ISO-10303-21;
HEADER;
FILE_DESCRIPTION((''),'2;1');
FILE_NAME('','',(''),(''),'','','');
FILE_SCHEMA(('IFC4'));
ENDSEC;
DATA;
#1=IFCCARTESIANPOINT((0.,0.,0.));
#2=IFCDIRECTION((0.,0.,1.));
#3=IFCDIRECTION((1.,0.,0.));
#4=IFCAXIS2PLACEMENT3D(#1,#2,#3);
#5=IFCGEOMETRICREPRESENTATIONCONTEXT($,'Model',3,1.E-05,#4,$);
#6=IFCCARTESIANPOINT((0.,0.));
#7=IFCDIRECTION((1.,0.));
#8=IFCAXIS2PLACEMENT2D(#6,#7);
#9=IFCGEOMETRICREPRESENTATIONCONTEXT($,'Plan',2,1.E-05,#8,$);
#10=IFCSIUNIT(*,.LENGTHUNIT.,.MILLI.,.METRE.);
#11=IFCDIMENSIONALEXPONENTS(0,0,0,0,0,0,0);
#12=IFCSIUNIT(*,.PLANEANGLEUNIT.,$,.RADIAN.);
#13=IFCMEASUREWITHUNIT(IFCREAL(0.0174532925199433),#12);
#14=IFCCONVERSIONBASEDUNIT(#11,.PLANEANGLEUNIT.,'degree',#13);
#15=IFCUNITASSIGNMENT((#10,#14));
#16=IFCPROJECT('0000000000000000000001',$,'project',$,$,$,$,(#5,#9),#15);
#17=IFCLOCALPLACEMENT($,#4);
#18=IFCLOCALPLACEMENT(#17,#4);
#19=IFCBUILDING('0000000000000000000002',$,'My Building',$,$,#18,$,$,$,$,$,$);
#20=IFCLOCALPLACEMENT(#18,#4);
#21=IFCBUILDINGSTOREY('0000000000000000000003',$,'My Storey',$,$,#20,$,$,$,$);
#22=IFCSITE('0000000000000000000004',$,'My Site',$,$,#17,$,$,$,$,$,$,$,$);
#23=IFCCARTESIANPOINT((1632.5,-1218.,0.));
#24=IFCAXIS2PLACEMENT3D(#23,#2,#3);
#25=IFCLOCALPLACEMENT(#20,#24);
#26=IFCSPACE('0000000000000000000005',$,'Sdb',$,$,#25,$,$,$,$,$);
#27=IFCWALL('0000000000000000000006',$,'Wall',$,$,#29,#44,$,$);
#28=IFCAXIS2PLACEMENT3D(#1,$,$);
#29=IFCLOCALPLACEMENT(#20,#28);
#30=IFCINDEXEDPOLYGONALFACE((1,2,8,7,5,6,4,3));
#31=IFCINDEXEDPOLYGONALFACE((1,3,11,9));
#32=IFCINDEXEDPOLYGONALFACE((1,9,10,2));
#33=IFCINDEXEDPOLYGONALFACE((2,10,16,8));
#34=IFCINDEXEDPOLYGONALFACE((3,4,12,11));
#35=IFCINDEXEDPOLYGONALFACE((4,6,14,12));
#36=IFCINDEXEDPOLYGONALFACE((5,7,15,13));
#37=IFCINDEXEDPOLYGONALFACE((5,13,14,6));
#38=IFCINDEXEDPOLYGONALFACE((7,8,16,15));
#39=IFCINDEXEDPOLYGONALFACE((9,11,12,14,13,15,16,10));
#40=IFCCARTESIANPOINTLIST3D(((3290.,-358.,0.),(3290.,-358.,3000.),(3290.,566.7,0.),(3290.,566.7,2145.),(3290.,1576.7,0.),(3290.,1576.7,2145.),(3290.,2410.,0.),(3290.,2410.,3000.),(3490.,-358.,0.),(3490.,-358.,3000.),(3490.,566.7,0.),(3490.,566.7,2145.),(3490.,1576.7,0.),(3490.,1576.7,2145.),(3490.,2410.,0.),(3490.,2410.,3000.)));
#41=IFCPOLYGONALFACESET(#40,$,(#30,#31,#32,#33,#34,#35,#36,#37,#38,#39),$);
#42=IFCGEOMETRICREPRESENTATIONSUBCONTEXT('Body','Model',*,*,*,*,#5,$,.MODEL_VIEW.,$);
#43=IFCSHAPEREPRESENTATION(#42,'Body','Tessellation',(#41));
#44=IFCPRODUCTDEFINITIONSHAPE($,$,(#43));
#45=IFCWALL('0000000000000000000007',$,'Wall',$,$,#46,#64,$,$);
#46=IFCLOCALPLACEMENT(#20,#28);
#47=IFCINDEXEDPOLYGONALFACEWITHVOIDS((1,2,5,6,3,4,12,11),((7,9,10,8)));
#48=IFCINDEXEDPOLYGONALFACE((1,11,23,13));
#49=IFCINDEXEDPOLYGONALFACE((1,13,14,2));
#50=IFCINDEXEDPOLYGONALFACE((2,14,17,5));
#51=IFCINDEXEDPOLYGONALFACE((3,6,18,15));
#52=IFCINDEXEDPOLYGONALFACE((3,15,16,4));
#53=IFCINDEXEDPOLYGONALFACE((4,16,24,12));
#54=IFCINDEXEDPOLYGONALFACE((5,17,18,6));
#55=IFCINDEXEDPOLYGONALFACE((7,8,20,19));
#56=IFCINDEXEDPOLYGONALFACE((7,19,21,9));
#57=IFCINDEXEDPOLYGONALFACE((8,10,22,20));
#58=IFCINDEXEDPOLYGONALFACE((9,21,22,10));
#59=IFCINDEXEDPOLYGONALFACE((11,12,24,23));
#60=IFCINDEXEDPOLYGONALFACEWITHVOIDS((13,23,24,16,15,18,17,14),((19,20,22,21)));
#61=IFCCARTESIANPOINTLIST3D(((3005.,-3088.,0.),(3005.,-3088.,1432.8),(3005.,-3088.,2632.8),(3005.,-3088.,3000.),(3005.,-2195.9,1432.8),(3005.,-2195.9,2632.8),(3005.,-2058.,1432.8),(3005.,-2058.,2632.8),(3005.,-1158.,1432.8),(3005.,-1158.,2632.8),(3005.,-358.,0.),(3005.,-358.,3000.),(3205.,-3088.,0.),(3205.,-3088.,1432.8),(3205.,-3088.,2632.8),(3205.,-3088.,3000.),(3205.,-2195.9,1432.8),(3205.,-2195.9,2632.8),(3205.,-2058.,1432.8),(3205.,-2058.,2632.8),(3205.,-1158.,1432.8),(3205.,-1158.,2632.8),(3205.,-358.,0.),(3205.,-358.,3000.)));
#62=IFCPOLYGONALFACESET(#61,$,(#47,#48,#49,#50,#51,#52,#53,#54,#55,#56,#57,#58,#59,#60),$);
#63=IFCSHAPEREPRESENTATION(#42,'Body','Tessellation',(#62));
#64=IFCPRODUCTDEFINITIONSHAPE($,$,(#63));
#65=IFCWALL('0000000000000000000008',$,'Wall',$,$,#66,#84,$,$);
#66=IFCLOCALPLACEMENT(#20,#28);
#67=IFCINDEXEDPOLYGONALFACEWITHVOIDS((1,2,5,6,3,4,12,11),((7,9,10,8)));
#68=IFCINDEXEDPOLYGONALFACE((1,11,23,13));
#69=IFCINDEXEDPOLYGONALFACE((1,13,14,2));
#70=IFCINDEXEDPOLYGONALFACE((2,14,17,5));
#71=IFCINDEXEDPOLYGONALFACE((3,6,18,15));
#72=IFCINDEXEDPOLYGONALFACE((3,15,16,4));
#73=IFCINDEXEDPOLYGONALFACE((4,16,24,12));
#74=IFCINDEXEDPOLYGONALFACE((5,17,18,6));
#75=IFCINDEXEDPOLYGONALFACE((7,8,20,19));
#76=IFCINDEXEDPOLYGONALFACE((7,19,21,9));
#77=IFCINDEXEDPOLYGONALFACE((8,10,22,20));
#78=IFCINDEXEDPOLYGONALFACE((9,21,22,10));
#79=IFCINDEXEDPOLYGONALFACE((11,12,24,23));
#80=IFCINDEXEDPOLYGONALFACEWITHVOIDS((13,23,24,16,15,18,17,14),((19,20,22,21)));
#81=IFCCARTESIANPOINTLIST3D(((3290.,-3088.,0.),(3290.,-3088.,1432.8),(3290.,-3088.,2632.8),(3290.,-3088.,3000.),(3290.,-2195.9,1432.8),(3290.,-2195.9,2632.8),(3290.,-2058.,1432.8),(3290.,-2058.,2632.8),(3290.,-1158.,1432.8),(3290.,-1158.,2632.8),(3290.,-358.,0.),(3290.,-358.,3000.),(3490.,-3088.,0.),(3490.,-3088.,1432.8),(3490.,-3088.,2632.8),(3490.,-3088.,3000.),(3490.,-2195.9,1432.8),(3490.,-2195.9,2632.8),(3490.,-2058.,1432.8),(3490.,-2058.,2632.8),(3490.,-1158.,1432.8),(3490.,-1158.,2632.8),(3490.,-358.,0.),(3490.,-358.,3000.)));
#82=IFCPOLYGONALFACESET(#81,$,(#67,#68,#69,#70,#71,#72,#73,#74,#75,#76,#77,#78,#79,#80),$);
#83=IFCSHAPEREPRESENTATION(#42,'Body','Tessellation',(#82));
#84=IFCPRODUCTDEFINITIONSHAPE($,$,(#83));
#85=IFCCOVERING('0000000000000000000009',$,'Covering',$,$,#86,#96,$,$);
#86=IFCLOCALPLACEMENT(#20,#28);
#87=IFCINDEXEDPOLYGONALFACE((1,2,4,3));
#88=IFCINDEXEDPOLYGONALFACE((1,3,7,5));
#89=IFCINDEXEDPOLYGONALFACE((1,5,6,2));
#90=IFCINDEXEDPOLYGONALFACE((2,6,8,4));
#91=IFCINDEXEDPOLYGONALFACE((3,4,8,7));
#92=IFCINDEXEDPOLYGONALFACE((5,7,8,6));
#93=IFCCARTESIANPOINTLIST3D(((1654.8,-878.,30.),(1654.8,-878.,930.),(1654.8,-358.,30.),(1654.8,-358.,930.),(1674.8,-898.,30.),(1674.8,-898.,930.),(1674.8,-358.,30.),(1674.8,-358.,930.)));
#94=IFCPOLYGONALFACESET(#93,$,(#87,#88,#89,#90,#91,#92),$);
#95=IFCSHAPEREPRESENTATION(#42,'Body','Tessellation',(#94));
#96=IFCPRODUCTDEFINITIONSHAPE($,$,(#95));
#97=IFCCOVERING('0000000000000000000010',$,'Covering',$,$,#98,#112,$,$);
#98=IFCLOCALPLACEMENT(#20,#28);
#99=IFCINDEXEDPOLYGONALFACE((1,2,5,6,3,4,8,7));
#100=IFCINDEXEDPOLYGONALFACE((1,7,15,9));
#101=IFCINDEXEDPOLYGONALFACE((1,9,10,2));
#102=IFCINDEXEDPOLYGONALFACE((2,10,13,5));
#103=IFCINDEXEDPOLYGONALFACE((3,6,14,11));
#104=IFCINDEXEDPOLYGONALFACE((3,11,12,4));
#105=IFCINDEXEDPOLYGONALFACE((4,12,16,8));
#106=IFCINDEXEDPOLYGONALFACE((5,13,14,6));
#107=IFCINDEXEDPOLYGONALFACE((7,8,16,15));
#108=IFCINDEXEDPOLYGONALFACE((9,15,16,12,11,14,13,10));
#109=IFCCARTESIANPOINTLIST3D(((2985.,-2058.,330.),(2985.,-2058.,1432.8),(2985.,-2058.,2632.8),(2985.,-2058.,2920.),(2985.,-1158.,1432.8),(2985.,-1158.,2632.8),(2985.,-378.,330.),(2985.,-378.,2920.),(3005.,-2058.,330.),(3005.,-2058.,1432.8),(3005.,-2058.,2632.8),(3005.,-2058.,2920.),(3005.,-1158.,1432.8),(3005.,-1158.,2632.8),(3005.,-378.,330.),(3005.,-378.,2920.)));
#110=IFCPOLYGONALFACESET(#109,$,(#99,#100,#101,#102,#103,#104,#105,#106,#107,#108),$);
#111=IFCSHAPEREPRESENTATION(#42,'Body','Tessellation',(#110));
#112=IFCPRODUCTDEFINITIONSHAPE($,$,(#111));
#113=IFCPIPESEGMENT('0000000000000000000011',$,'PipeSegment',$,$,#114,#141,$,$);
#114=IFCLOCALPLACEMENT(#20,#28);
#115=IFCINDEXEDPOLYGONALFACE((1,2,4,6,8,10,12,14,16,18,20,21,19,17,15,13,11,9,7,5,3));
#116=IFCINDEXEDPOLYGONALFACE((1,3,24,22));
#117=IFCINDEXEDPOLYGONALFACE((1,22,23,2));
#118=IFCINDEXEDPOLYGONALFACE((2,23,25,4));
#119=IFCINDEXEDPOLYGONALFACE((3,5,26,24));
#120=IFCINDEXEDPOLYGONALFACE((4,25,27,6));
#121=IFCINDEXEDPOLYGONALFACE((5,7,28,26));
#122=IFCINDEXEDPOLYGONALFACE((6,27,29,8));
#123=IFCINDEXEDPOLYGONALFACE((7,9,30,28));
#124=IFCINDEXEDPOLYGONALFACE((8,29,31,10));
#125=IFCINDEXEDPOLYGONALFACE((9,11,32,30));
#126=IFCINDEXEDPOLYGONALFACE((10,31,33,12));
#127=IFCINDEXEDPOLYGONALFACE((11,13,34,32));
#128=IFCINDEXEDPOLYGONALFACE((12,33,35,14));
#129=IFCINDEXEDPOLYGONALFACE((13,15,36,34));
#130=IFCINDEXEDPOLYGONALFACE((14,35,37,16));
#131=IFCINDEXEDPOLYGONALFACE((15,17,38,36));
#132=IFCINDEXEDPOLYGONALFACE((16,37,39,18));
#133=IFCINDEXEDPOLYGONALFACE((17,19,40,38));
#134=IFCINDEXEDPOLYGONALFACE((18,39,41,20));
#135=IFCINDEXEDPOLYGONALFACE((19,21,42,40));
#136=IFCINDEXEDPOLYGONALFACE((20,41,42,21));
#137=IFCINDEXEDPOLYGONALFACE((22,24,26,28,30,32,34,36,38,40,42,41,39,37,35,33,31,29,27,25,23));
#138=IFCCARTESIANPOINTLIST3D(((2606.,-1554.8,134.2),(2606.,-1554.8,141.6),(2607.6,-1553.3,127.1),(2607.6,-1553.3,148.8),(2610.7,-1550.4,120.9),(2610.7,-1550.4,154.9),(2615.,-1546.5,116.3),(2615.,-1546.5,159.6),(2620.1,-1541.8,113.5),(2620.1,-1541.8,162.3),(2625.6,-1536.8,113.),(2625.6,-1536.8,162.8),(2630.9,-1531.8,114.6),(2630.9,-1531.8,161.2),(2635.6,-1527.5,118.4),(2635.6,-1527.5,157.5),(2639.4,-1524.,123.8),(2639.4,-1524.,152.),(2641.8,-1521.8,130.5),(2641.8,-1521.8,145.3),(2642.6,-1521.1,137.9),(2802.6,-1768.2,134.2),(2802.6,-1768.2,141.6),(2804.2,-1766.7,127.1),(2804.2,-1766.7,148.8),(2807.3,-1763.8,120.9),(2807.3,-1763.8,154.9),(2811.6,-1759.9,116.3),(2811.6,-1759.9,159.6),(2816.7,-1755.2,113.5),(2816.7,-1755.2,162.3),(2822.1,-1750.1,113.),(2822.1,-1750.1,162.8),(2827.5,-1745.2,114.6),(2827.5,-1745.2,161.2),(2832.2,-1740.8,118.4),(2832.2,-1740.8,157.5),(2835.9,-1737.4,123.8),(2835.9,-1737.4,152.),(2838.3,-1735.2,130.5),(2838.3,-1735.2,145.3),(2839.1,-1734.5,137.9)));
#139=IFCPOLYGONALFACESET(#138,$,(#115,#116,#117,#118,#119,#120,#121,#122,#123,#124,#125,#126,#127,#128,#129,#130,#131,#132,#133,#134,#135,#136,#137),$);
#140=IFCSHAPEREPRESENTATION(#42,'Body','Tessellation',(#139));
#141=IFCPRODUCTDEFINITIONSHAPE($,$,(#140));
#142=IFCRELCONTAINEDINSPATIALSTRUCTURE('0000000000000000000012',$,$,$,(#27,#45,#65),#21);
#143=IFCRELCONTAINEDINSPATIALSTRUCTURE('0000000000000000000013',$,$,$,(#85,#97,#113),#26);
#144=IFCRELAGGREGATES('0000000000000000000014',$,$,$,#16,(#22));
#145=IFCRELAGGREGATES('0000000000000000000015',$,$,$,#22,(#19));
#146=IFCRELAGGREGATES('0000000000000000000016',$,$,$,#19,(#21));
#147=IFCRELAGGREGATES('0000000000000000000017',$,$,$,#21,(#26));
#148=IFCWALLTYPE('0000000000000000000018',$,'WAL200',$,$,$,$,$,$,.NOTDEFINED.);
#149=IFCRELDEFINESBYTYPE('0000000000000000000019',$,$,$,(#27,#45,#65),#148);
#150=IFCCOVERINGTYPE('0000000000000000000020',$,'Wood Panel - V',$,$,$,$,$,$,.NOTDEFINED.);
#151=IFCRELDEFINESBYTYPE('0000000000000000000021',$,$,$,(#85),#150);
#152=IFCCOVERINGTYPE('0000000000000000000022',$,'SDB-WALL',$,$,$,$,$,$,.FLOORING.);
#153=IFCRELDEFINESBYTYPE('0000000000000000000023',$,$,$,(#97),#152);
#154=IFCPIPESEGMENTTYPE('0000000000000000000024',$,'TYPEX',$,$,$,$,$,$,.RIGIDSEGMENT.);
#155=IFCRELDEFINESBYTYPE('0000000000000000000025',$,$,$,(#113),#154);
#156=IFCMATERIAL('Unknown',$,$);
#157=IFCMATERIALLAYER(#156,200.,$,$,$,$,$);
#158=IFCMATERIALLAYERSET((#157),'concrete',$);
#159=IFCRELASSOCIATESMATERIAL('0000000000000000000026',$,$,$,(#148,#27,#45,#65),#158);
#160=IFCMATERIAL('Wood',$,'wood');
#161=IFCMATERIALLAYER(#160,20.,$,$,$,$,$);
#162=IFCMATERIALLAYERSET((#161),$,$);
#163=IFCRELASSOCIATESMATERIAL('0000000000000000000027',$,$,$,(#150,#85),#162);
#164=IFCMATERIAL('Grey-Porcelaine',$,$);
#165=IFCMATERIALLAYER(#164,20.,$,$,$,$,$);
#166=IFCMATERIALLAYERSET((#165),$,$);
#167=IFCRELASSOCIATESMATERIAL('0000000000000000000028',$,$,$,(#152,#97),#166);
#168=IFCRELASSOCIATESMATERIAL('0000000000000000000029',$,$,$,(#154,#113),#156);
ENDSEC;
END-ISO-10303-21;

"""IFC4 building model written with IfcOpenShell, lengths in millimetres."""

from ifc_helpers import new_model, entity, si_unit, converted_unit, frame, origin_with_axes, origin_2d_with_axis, place, context, subcontext, project, spatial, line, indexed_curve, circle, outline, extrude, clip, halfspace, source, transform, mapped, material, layer, layer_set, layer_usage, material_profile, profile_set, profile_usage, type_object, element, save


model = new_model("IFC4")

# Units and contexts
model_context = context("Model", 3, precision=1e-05, world=origin_with_axes())
plan_context = context("Plan", 2, precision=1e-05, world=origin_2d_with_axis())
body_context = subcontext(model_context, "Body", "Model", "MODEL_VIEW")
ifc_project = project(units=[si_unit("LENGTHUNIT", "METRE", prefix="MILLI"), converted_unit("PLANEANGLEUNIT", "degree", entity("IfcReal", 0.0174532925199433), si_unit("PLANEANGLEUNIT", "RADIAN"), dimensions=[0, 0, 0, 0, 0, 0, 0])], contexts=[model_context, plan_context])

# Site, building, storey, space
site_placement = place(None, origin_with_axes())
site = spatial("IfcSite", under=ifc_project, at=site_placement, Name="My Site")
building_placement = place(site_placement, origin_with_axes())
building = spatial("IfcBuilding", under=site, at=building_placement, Name="My Building")
storey_placement = place(building_placement, origin_with_axes())
storey = spatial("IfcBuildingStorey", under=building, at=storey_placement, Name="My Storey")
space_1_placement = place(storey_placement, frame((1632.5, -1218.0, 0.0), z_axis=(0.0, 0.0, 1.0), x_axis=(1.0, 0.0, 0.0)))
space_1 = spatial("IfcSpace", under=storey, at=space_1_placement, Name="Sdb")

# Shared definitions
ifc_material_1 = material(Name="Unknown")

# Wall, opening
ifc_layer_1 = layer(ifc_material_1, 200.0)
ifc_layer_set_1 = layer_set([ifc_layer_1], Name="concrete")
ifc_layer_usage_1 = layer_usage(ifc_layer_set_1, "AXIS2", "POSITIVE", 0.0)
wall_type = type_object("IfcWallType", Name="WAL200", PredefinedType="NOTDEFINED", material=ifc_layer_set_1)
wall_1_placement = place(storey_placement, frame((3490.0, -358.0, 0.0), z_axis=(0.0, 0.0, 1.0), x_axis=(0.0, 1.0, 0.0)))
wall_1 = element("IfcWall", 1, at=wall_1_placement, inside=storey, type_object=wall_type, material=ifc_layer_usage_1, Name="Wall", context=body_context, shape_type="SweptSolid", body=[
    extrude(outline(indexed_curve([(0.0, 0.0), (0.0, 200.0), (2768.0, 200.0), (2768.0, 0.0), (0.0, 0.0)], self_intersect=False)), origin_with_axes(), (0.0, 0.0, 1.0), 3000.0),
])
shared_shape_1 = source(origin_with_axes(), body_context, "Body", "SweptSolid", [
    extrude(outline(indexed_curve([(0.0, 0.0), (1010.0, 0.0), (1010.0, 2145.0), (0.0, 2145.0)], segments=[line(1, 2, 3, 4, 1)])), frame((0.0, -600.0, 0.0), z_axis=(0.0, -1.0, 0.0), x_axis=(1.0, 0.0, 0.0)), (0.0, 0.0, -1.0), 1200.0),
])
opening_1_placement = place(wall_1_placement, frame((924.7, 0.0, 0.0), z_axis=(0.0, 0.0, 1.0), x_axis=(1.0, 0.0, 0.0)))
element("IfcOpeningElement", 2, at=opening_1_placement, cuts=wall_1, PredefinedType="OPENING", context=body_context, shape_type="MappedRepresentation", body=[
    mapped(shared_shape_1, transform((0.0, 0.0, 0.0), x_axis=(1.0, 0.0, 0.0), y_axis=(0.0, 1.0, 0.0), z_axis=(0.0, 0.0, 1.0), scale=1.0)),
])

# Walls, openings
ifc_layer_usage_2 = layer_usage(ifc_layer_set_1, "AXIS2", "POSITIVE", 0.0)
wall_2_placement = place(storey_placement, frame((3005.0, -358.0, 0.0), z_axis=(0.0, 0.0, 1.0), x_axis=(-0.000001, -1.0, 0.0)))
wall_2 = element("IfcWall", 3, at=wall_2_placement, inside=storey, type_object=wall_type, material=ifc_layer_usage_2, Name="Wall", context=body_context, shape_type="SweptSolid", body=[
    extrude(outline(indexed_curve([(0.0, 0.0), (0.0, 200.0), (2730.0, 200.0), (2730.0, 0.0), (0.0, 0.0)], self_intersect=False)), origin_with_axes(), (0.0, 0.0, 1.0), 3000.0),
])
shared_shape_2 = source(origin_with_axes(), body_context, "Body", "SweptSolid", [
    extrude(outline(indexed_curve([(0.0, 0.0), (900.0, 0.0), (900.0, 1200.0), (0.0, 1200.0)], segments=[line(1, 2, 3, 4, 1)])), frame((0.0, -600.0, 0.0), z_axis=(0.0, -1.0, 0.0), x_axis=(1.0, 0.0, 0.0)), (0.0, 0.0, -1.0), 1200.0),
])
opening_2_placement = place(wall_2_placement, frame((1837.9, 0.0, 1432.8), z_axis=(0.0, 0.0, 1.0), x_axis=(1.0, 0.0, 0.0)))
element("IfcOpeningElement", 4, at=opening_2_placement, cuts=wall_2, PredefinedType="OPENING", context=body_context, shape_type="MappedRepresentation", body=[
    mapped(shared_shape_2, transform((0.0, 0.0, 0.0), x_axis=(1.0, 0.0, 0.0), y_axis=(0.0, 1.0, 0.0), z_axis=(0.0, 0.0, 1.0), scale=1.0)),
])
shared_shape_3 = source(origin_with_axes(), body_context, "Body", "SweptSolid", [
    extrude(outline(indexed_curve([(0.0, 0.0), (900.0, 0.0), (900.0, 1200.0), (0.0, 1200.0)], segments=[line(1, 2, 3, 4, 1)])), frame((0.0, -600.0, 0.0), z_axis=(0.0, -1.0, 0.0), x_axis=(1.0, 0.0, 0.0)), (0.0, 0.0, -1.0), 1200.0),
])
opening_3_placement = place(wall_2_placement, frame((800.0, 0.0, 1432.8), z_axis=(0.0, 0.0, 1.0), x_axis=(1.0, 0.0, 0.0)))
element("IfcOpeningElement", 5, at=opening_3_placement, cuts=wall_2, PredefinedType="OPENING", context=body_context, shape_type="MappedRepresentation", body=[
    mapped(shared_shape_3, transform((0.0, 0.0, 0.0), x_axis=(1.0, 0.0, 0.0), y_axis=(0.0, 1.0, 0.0), z_axis=(0.0, 0.0, 1.0), scale=1.0)),
])
ifc_layer_usage_3 = layer_usage(ifc_layer_set_1, "AXIS2", "POSITIVE", 0.0)
wall_3_placement = place(storey_placement, frame((3290.0, -358.0, 0.0), z_axis=(0.0, 0.0, 1.0), x_axis=(-0.000001, -1.0, 0.0)))
wall_3 = element("IfcWall", 6, at=wall_3_placement, inside=storey, type_object=wall_type, material=ifc_layer_usage_3, Name="Wall", context=body_context, shape_type="SweptSolid", body=[
    extrude(outline(indexed_curve([(0.0, 0.0), (0.0, 200.0), (2730.0, 200.0), (2730.0, 0.0), (0.0, 0.0)], self_intersect=False)), origin_with_axes(), (0.0, 0.0, 1.0), 3000.0),
])
shared_shape_4 = source(origin_with_axes(), body_context, "Body", "SweptSolid", [
    extrude(outline(indexed_curve([(0.0, 0.0), (900.0, 0.0), (900.0, 1200.0), (0.0, 1200.0)], segments=[line(1, 2, 3, 4, 1)])), frame((0.0, -600.0, 0.0), z_axis=(0.0, -1.0, 0.0), x_axis=(1.0, 0.0, 0.0)), (0.0, 0.0, -1.0), 1200.0),
])
opening_4_placement = place(wall_3_placement, frame((800.0, -285.0, 1432.8), z_axis=(0.0, 0.0, 1.0), x_axis=(1.0, 0.0, 0.0)))
element("IfcOpeningElement", 7, at=opening_4_placement, cuts=wall_3, PredefinedType="OPENING", context=body_context, shape_type="MappedRepresentation", body=[
    mapped(shared_shape_4, transform((0.0, 0.0, 0.0), x_axis=(1.0, 0.0, 0.0), y_axis=(0.0, 1.0, 0.0), z_axis=(0.0, 0.0, 1.0), scale=1.0)),
])
shared_shape_5 = source(origin_with_axes(), body_context, "Body", "SweptSolid", [
    extrude(outline(indexed_curve([(0.0, 0.0), (900.0, 0.0), (900.0, 1200.0), (0.0, 1200.0)], segments=[line(1, 2, 3, 4, 1)])), frame((0.0, -600.0, 0.0), z_axis=(0.0, -1.0, 0.0), x_axis=(1.0, 0.0, 0.0)), (0.0, 0.0, -1.0), 1200.0),
])
opening_5_placement = place(wall_3_placement, frame((1837.9, -285.0, 1432.8), z_axis=(0.0, 0.0, 1.0), x_axis=(1.0, 0.0, 0.0)))
element("IfcOpeningElement", 8, at=opening_5_placement, cuts=wall_3, PredefinedType="OPENING", context=body_context, shape_type="MappedRepresentation", body=[
    mapped(shared_shape_5, transform((0.0, 0.0, 0.0), x_axis=(1.0, 0.0, 0.0), y_axis=(0.0, 1.0, 0.0), z_axis=(0.0, 0.0, 1.0), scale=1.0)),
])

# Covering
ifc_material_2 = material(Name="Wood", Category="wood")
ifc_layer_2 = layer(ifc_material_2, 20.0)
ifc_layer_set_2 = layer_set([ifc_layer_2])
ifc_layer_usage_4 = layer_usage(ifc_layer_set_2, "AXIS2", "POSITIVE", 0.0)
covering_type_1 = type_object("IfcCoveringType", Name="Wood Panel - V", PredefinedType="NOTDEFINED", material=ifc_layer_set_2)
covering_1_placement = place(space_1_placement, frame((42.3, 320.0, 30.0), z_axis=(0.0, 0.0, 1.0), x_axis=(0.0, 1.0, 0.0)))
element("IfcCovering", 9, at=covering_1_placement, inside=space_1, type_object=covering_type_1, material=ifc_layer_usage_4, Name="Covering", context=body_context, shape_type="Clipping", body=[
    clip(clip(extrude(outline(indexed_curve([(0.0, 0.0), (0.0, 20.0), (540.0, 20.0), (540.0, 0.0), (0.0, 0.0)], self_intersect=False)), origin_with_axes(), (0.0, 0.0, 1.0), 930.0), halfspace(frame((0.0, 0.0, 900.0), z_axis=(0.0, 0.0, 1.0), x_axis=(-1.0, 0.0, 0.0)), False)), halfspace(frame((0.0, 0.0, -30.0), z_axis=(-0.707107, 0.707107, 0.0), x_axis=(0.707107, 0.707107, 0.0)), False)),
])

# Covering, opening
ifc_material_3 = material(Name="Grey-Porcelaine")
ifc_layer_3 = layer(ifc_material_3, 20.0)
ifc_layer_set_3 = layer_set([ifc_layer_3])
ifc_layer_usage_5 = layer_usage(ifc_layer_set_3, "AXIS2", "POSITIVE", 0.0)
covering_type_2 = type_object("IfcCoveringType", Name="SDB-WALL", PredefinedType="FLOORING", material=ifc_layer_set_3)
covering_2_placement = place(space_1_placement, frame((1352.5, 840.0, 330.0), z_axis=(0.0, 0.0, 1.0), x_axis=(0.0, -1.0, 0.0)))
covering_2 = element("IfcCovering", 10, at=covering_2_placement, inside=space_1, type_object=covering_type_2, material=ifc_layer_usage_5, Name="Covering", context=body_context, shape_type="Clipping", body=[
    clip(extrude(outline(indexed_curve([(0.0, 0.0), (0.0, 20.0), (1680.0, 20.0), (1680.0, 0.0), (0.0, 0.0)], self_intersect=False)), origin_with_axes(), (0.0, 0.0, 1.0), 2920.0), halfspace(frame((0.0, 0.0, 2590.0), z_axis=(0.0, 0.0, 1.0), x_axis=(-1.0, 0.0, 0.0)), False)),
])
shared_shape_6 = source(origin_with_axes(), body_context, "Body", "SweptSolid", [
    extrude(outline(indexed_curve([(0.0, 0.0), (900.0, 0.0), (900.0, 1200.0), (0.0, 1200.0)], segments=[line(1, 2, 3, 4, 1)])), frame((0.0, -600.0, 0.0), z_axis=(0.0, -1.0, 0.0), x_axis=(1.0, 0.0, 0.0)), (0.0, 0.0, -1.0), 1200.0),
])
opening_6_placement = place(covering_2_placement, frame((780.0, 20.0, 1102.8), z_axis=(0.0, 0.0, 1.0), x_axis=(1.0, 0.0, 0.0)))
element("IfcOpeningElement", 11, at=opening_6_placement, cuts=covering_2, PredefinedType="OPENING", context=body_context, shape_type="MappedRepresentation", body=[
    mapped(shared_shape_6, transform((0.0, 0.0, 0.0), x_axis=(1.0, 0.0, 0.0), y_axis=(0.0, 1.0, 0.0), z_axis=(0.0, 0.0, 1.0), scale=1.0)),
])

# Pipe segment
ifc_material_profile = material_profile(ifc_material_1, circle(Radius=25.0))
ifc_profile_set = profile_set([ifc_material_profile])
ifc_profile_usage_1 = profile_usage(ifc_profile_set, cardinal=5)
pipe_segment_type = type_object("IfcPipeSegmentType", Name="TYPEX", PredefinedType="RIGIDSEGMENT", material=ifc_profile_set)
pipe_segment_1_placement = place(space_1_placement, frame((991.7, -320.0, 137.9), z_axis=(0.677548, -0.735479, 0.0), x_axis=(0.735479, 0.677548, 0.0)))
element("IfcPipeSegment", 12, at=pipe_segment_1_placement, inside=space_1, type_object=pipe_segment_type, material=ifc_profile_usage_1, Name="PipeSegment", context=body_context, shape_type="SweptSolid", body=[
    extrude(circle(Radius=25.0), origin_with_axes(), (0.0, 0.0, 1.0), 290.1),
])

save(model, "model.ifc")
